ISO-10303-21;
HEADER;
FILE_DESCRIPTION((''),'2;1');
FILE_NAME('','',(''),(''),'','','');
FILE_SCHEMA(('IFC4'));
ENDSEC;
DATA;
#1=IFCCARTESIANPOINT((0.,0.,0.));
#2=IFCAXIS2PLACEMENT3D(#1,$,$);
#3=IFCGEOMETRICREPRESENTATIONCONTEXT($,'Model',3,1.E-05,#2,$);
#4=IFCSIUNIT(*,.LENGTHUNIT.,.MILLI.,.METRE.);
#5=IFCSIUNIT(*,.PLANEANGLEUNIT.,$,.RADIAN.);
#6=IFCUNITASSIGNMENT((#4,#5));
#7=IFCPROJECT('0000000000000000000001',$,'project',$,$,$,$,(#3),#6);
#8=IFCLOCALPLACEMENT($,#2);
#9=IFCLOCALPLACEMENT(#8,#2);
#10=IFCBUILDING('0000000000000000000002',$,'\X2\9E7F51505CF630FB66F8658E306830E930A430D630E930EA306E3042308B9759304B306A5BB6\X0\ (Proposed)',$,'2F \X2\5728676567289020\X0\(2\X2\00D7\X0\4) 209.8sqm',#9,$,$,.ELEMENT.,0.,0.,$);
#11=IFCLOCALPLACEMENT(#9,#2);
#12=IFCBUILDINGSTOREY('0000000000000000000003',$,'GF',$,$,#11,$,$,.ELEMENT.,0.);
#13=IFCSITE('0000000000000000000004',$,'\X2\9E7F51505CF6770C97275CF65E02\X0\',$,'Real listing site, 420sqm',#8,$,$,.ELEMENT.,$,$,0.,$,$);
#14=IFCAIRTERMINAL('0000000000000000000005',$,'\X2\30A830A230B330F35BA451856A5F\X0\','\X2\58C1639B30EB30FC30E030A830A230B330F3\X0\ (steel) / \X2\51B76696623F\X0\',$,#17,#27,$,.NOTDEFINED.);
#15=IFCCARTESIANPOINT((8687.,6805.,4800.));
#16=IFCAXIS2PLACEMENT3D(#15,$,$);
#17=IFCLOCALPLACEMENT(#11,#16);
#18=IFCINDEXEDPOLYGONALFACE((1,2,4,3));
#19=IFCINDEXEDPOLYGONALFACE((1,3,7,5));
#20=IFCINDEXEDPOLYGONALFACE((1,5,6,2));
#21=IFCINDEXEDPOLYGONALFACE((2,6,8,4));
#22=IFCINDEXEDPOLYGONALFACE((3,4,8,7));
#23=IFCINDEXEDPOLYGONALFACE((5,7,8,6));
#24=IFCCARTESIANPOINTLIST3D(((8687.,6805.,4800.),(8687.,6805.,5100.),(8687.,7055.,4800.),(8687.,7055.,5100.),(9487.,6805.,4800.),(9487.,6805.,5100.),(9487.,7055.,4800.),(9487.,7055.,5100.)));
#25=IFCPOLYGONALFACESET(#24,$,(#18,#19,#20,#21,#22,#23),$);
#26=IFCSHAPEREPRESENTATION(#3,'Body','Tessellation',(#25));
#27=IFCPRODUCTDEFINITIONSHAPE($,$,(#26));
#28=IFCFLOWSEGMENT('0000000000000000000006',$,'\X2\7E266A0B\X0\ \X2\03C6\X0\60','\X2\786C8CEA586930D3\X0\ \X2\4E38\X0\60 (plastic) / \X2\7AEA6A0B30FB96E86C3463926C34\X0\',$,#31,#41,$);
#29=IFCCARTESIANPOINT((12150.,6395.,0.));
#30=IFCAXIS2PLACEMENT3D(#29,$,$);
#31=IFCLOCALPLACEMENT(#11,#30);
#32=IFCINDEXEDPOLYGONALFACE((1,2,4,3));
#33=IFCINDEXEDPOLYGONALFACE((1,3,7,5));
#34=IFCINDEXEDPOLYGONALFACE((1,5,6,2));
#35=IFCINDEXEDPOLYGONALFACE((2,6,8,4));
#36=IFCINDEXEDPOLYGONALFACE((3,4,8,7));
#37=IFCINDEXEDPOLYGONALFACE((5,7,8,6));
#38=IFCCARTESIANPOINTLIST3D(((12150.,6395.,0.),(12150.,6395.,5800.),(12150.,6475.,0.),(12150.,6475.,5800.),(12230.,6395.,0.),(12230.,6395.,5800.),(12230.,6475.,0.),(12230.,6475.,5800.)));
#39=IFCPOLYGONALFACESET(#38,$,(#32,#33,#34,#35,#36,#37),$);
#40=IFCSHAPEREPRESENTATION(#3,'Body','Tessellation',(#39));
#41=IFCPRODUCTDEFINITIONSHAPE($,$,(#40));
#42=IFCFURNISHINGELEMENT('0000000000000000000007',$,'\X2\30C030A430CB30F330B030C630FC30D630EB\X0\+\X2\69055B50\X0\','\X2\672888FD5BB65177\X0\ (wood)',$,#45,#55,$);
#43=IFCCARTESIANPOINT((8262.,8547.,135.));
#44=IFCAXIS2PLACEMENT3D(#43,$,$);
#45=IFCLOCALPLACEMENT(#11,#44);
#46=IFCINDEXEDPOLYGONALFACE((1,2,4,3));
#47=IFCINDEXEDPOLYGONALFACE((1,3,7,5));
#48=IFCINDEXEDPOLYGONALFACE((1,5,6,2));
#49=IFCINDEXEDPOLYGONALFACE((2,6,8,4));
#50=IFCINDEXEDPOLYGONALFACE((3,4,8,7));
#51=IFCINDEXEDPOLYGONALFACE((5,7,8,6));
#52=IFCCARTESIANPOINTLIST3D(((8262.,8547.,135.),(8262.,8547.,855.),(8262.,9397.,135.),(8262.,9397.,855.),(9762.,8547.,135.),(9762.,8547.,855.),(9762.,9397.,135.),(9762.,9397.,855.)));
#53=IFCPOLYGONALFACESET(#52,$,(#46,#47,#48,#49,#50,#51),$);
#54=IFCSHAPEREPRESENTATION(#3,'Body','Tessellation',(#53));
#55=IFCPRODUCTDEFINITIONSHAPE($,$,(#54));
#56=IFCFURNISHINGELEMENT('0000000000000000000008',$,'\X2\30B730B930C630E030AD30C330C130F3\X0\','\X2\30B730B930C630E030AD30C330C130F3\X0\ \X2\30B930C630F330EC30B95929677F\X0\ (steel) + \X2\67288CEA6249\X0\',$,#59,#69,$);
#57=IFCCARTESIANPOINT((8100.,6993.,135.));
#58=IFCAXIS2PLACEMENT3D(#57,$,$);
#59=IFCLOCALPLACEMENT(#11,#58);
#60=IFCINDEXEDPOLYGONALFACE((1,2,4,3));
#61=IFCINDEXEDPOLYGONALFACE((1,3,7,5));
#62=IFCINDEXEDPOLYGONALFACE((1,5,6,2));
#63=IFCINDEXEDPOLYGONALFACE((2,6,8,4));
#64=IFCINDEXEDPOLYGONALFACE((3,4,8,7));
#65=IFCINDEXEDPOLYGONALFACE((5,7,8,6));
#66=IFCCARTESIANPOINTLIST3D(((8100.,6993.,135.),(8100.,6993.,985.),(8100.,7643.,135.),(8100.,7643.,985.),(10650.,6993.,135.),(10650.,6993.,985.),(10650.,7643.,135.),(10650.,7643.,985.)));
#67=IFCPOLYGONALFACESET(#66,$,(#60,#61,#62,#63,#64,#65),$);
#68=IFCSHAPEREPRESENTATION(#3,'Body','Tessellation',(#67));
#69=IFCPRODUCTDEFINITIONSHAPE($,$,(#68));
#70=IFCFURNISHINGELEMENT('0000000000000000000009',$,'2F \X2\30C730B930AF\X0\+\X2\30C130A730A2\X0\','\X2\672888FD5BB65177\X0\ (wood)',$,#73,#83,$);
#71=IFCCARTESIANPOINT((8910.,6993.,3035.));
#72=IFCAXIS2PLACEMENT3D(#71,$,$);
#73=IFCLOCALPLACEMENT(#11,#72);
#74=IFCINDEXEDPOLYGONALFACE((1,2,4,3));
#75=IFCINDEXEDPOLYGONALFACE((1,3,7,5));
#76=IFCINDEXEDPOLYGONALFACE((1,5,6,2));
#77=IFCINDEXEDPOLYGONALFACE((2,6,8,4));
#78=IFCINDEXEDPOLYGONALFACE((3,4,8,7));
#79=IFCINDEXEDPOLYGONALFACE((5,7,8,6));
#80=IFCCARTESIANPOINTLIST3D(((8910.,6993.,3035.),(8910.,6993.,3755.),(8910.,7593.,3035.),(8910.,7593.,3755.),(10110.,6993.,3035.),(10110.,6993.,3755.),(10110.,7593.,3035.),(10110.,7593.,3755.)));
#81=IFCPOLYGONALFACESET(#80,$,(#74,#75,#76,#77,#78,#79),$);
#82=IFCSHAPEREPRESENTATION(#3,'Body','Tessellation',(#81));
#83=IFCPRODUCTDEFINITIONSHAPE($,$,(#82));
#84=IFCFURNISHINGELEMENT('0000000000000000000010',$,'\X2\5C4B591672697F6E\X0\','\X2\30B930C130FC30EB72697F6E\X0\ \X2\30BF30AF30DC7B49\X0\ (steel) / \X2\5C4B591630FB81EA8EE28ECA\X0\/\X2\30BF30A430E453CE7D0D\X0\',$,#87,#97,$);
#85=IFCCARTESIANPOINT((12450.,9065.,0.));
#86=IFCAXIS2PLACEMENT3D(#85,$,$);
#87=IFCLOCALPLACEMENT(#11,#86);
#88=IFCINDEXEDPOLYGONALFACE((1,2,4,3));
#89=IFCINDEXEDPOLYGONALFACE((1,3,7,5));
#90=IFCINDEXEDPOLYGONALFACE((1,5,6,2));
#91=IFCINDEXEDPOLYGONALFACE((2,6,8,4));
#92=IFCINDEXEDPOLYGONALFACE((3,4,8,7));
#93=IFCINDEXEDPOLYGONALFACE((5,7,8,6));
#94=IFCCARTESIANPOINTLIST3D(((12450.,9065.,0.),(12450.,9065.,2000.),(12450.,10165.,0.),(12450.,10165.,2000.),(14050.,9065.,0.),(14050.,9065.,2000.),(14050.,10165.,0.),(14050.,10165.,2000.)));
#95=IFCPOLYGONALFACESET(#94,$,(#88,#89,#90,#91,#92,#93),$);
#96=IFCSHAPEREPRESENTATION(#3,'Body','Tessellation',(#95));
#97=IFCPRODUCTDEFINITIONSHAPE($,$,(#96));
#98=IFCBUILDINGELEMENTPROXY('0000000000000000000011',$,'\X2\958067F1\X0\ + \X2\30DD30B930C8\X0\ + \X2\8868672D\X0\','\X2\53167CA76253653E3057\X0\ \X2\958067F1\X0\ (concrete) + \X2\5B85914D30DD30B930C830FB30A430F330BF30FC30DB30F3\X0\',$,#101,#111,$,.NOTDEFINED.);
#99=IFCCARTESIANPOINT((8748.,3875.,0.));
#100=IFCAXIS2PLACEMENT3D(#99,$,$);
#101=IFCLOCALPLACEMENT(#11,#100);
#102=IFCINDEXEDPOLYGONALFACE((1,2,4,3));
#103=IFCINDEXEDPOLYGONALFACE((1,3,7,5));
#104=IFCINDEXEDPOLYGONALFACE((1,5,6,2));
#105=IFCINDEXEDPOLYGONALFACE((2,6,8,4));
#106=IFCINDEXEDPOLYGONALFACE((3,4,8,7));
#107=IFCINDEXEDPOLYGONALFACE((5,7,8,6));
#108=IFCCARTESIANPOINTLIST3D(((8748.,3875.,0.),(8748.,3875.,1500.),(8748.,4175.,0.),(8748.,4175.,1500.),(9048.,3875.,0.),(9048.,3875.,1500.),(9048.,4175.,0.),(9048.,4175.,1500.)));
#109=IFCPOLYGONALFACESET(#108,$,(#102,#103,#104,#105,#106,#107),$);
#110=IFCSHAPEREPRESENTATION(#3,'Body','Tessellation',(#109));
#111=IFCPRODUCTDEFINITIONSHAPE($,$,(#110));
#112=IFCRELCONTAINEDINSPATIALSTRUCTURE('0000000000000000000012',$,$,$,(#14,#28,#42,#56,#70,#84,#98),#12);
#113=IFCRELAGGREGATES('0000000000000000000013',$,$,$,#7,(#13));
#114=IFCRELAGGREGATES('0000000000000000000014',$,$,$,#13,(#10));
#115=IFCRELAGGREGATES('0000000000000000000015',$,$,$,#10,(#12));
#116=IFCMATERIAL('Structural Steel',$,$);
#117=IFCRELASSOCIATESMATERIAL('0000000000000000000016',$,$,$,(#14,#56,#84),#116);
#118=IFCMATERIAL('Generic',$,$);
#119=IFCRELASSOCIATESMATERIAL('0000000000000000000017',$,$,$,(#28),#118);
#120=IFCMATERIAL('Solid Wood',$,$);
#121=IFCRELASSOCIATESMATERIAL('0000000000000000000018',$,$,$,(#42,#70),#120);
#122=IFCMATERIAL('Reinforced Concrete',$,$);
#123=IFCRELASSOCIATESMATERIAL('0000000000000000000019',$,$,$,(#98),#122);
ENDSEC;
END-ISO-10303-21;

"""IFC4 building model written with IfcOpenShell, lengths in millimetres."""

from ifc_helpers import new_model, si_unit, frame, frame_2d, origin, place, context, project, spatial, rectangle, extrude, material, element, save


model = new_model("IFC4")

# Units and contexts
model_context = context("Model", 3, precision=1e-05, world=origin())
ifc_project = project(units=[si_unit("LENGTHUNIT", "METRE", prefix="MILLI"), si_unit("PLANEANGLEUNIT", "RADIAN")], contexts=[model_context])

# Site, building, storey
site_placement = place(None, origin())
site = spatial("IfcSite", under=ifc_project, at=site_placement, Name="鹿児島県霧島市", ObjectType="Real listing site, 420sqm", CompositionType="ELEMENT", RefElevation=0.0)
building_placement = place(site_placement, origin())
building = spatial("IfcBuilding", under=site, at=building_placement, Name="鹿児島・書斎とライブラリのある静かな家 (Proposed)", ObjectType="2F 在来木造(2×4) 209.8sqm", CompositionType="ELEMENT", ElevationOfRefHeight=0.0, ElevationOfTerrain=0.0)
storey_placement = place(building_placement, origin())
storey = spatial("IfcBuildingStorey", under=building, at=storey_placement, Name="GF", CompositionType="ELEMENT", Elevation=0.0)

# Shared definitions
ifc_material_1 = material(Name="Solid Wood")

# Shared definitions
ifc_material_2 = material(Name="Reinforced Concrete")

# Shared definitions
ifc_material_3 = material(Name="Structural Steel")

# Shared definitions
ifc_material_4 = material(Name="Generic")

# Air terminal
air_terminal_placement = place(storey_placement, frame((8687.0, 6805.0, 4800.0)))
element("IfcAirTerminal", 1, at=air_terminal_placement, inside=storey, material=ifc_material_3, Name="エアコン室内機", Description="壁掛ルームエアコン (steel) / 冷暖房", PredefinedType="NOTDEFINED", context=model_context, shape_type="SweptSolid", body=[
    extrude(rectangle(XDim=800.0, YDim=250.0, at=frame_2d((400.0, 125.0))), frame((8687.0, 6805.0, 4800.0)), (0.0, 0.0, 1.0), 300.0),
])

# Flow segment
flow_segment_placement = place(storey_placement, frame((12150.0, 6395.0, 0.0)))
element("IfcFlowSegment", 2, at=flow_segment_placement, inside=storey, material=ifc_material_4, Name="縦樋 φ60", Description="硬質塩ビ 丸60 (plastic) / 竪樋・雨水排水", context=model_context, shape_type="SweptSolid", body=[
    extrude(rectangle(XDim=80.0, YDim=80.0, at=frame_2d((40.0, 40.0))), frame((12150.0, 6395.0, 0.0)), (0.0, 0.0, 1.0), 5800.0),
])

# Furnishing elements
furnishing_1_placement = place(storey_placement, frame((8262.0, 8547.0, 135.0)))
element("IfcFurnishingElement", 3, at=furnishing_1_placement, inside=storey, material=ifc_material_1, Name="ダイニングテーブル+椅子", Description="木製家具 (wood)", context=model_context, shape_type="SweptSolid", body=[
    extrude(rectangle(XDim=1500.0, YDim=850.0, at=frame_2d((750.0, 425.0))), frame((8262.0, 8547.0, 135.0)), (0.0, 0.0, 1.0), 720.0),
])
furnishing_2_placement = place(storey_placement, frame((8100.0, 6993.0, 135.0)))
element("IfcFurnishingElement", 4, at=furnishing_2_placement, inside=storey, material=ifc_material_3, Name="システムキッチン", Description="システムキッチン ステンレス天板 (steel) + 木質扉", context=model_context, shape_type="SweptSolid", body=[
    extrude(rectangle(XDim=2550.0, YDim=650.0, at=frame_2d((1275.0, 325.0))), frame((8100.0, 6993.0, 135.0)), (0.0, 0.0, 1.0), 850.0),
])
furnishing_3_placement = place(storey_placement, frame((8910.0, 6993.0, 3035.0)))
element("IfcFurnishingElement", 5, at=furnishing_3_placement, inside=storey, material=ifc_material_1, Name="2F デスク+チェア", Description="木製家具 (wood)", context=model_context, shape_type="SweptSolid", body=[
    extrude(rectangle(XDim=1200.0, YDim=600.0, at=frame_2d((600.0, 300.0))), frame((8910.0, 6993.0, 3035.0)), (0.0, 0.0, 1.0), 720.0),
])
furnishing_4_placement = place(storey_placement, frame((12450.0, 9065.0, 0.0)))
element("IfcFurnishingElement", 6, at=furnishing_4_placement, inside=storey, material=ifc_material_3, Name="屋外物置", Description="スチール物置 タクボ等 (steel) / 屋外・自転車/タイヤ収納", context=model_context, shape_type="SweptSolid", body=[
    extrude(rectangle(XDim=1600.0, YDim=1100.0, at=frame_2d((800.0, 550.0))), frame((12450.0, 9065.0, 0.0)), (0.0, 0.0, 1.0), 2000.0),
])

# Building element proxy
proxy_placement = place(storey_placement, frame((8748.0, 3875.0, 0.0)))
element("IfcBuildingElementProxy", 7, at=proxy_placement, inside=storey, material=ifc_material_2, Name="門柱 + ポスト + 表札", Description="化粧打放し 門柱 (concrete) + 宅配ポスト・インターホン", PredefinedType="NOTDEFINED", context=model_context, shape_type="SweptSolid", body=[
    extrude(rectangle(XDim=300.0, YDim=300.0, at=frame_2d((150.0, 150.0))), frame((8748.0, 3875.0, 0.0)), (0.0, 0.0, 1.0), 1500.0),
])

save(model, "model.ifc")
